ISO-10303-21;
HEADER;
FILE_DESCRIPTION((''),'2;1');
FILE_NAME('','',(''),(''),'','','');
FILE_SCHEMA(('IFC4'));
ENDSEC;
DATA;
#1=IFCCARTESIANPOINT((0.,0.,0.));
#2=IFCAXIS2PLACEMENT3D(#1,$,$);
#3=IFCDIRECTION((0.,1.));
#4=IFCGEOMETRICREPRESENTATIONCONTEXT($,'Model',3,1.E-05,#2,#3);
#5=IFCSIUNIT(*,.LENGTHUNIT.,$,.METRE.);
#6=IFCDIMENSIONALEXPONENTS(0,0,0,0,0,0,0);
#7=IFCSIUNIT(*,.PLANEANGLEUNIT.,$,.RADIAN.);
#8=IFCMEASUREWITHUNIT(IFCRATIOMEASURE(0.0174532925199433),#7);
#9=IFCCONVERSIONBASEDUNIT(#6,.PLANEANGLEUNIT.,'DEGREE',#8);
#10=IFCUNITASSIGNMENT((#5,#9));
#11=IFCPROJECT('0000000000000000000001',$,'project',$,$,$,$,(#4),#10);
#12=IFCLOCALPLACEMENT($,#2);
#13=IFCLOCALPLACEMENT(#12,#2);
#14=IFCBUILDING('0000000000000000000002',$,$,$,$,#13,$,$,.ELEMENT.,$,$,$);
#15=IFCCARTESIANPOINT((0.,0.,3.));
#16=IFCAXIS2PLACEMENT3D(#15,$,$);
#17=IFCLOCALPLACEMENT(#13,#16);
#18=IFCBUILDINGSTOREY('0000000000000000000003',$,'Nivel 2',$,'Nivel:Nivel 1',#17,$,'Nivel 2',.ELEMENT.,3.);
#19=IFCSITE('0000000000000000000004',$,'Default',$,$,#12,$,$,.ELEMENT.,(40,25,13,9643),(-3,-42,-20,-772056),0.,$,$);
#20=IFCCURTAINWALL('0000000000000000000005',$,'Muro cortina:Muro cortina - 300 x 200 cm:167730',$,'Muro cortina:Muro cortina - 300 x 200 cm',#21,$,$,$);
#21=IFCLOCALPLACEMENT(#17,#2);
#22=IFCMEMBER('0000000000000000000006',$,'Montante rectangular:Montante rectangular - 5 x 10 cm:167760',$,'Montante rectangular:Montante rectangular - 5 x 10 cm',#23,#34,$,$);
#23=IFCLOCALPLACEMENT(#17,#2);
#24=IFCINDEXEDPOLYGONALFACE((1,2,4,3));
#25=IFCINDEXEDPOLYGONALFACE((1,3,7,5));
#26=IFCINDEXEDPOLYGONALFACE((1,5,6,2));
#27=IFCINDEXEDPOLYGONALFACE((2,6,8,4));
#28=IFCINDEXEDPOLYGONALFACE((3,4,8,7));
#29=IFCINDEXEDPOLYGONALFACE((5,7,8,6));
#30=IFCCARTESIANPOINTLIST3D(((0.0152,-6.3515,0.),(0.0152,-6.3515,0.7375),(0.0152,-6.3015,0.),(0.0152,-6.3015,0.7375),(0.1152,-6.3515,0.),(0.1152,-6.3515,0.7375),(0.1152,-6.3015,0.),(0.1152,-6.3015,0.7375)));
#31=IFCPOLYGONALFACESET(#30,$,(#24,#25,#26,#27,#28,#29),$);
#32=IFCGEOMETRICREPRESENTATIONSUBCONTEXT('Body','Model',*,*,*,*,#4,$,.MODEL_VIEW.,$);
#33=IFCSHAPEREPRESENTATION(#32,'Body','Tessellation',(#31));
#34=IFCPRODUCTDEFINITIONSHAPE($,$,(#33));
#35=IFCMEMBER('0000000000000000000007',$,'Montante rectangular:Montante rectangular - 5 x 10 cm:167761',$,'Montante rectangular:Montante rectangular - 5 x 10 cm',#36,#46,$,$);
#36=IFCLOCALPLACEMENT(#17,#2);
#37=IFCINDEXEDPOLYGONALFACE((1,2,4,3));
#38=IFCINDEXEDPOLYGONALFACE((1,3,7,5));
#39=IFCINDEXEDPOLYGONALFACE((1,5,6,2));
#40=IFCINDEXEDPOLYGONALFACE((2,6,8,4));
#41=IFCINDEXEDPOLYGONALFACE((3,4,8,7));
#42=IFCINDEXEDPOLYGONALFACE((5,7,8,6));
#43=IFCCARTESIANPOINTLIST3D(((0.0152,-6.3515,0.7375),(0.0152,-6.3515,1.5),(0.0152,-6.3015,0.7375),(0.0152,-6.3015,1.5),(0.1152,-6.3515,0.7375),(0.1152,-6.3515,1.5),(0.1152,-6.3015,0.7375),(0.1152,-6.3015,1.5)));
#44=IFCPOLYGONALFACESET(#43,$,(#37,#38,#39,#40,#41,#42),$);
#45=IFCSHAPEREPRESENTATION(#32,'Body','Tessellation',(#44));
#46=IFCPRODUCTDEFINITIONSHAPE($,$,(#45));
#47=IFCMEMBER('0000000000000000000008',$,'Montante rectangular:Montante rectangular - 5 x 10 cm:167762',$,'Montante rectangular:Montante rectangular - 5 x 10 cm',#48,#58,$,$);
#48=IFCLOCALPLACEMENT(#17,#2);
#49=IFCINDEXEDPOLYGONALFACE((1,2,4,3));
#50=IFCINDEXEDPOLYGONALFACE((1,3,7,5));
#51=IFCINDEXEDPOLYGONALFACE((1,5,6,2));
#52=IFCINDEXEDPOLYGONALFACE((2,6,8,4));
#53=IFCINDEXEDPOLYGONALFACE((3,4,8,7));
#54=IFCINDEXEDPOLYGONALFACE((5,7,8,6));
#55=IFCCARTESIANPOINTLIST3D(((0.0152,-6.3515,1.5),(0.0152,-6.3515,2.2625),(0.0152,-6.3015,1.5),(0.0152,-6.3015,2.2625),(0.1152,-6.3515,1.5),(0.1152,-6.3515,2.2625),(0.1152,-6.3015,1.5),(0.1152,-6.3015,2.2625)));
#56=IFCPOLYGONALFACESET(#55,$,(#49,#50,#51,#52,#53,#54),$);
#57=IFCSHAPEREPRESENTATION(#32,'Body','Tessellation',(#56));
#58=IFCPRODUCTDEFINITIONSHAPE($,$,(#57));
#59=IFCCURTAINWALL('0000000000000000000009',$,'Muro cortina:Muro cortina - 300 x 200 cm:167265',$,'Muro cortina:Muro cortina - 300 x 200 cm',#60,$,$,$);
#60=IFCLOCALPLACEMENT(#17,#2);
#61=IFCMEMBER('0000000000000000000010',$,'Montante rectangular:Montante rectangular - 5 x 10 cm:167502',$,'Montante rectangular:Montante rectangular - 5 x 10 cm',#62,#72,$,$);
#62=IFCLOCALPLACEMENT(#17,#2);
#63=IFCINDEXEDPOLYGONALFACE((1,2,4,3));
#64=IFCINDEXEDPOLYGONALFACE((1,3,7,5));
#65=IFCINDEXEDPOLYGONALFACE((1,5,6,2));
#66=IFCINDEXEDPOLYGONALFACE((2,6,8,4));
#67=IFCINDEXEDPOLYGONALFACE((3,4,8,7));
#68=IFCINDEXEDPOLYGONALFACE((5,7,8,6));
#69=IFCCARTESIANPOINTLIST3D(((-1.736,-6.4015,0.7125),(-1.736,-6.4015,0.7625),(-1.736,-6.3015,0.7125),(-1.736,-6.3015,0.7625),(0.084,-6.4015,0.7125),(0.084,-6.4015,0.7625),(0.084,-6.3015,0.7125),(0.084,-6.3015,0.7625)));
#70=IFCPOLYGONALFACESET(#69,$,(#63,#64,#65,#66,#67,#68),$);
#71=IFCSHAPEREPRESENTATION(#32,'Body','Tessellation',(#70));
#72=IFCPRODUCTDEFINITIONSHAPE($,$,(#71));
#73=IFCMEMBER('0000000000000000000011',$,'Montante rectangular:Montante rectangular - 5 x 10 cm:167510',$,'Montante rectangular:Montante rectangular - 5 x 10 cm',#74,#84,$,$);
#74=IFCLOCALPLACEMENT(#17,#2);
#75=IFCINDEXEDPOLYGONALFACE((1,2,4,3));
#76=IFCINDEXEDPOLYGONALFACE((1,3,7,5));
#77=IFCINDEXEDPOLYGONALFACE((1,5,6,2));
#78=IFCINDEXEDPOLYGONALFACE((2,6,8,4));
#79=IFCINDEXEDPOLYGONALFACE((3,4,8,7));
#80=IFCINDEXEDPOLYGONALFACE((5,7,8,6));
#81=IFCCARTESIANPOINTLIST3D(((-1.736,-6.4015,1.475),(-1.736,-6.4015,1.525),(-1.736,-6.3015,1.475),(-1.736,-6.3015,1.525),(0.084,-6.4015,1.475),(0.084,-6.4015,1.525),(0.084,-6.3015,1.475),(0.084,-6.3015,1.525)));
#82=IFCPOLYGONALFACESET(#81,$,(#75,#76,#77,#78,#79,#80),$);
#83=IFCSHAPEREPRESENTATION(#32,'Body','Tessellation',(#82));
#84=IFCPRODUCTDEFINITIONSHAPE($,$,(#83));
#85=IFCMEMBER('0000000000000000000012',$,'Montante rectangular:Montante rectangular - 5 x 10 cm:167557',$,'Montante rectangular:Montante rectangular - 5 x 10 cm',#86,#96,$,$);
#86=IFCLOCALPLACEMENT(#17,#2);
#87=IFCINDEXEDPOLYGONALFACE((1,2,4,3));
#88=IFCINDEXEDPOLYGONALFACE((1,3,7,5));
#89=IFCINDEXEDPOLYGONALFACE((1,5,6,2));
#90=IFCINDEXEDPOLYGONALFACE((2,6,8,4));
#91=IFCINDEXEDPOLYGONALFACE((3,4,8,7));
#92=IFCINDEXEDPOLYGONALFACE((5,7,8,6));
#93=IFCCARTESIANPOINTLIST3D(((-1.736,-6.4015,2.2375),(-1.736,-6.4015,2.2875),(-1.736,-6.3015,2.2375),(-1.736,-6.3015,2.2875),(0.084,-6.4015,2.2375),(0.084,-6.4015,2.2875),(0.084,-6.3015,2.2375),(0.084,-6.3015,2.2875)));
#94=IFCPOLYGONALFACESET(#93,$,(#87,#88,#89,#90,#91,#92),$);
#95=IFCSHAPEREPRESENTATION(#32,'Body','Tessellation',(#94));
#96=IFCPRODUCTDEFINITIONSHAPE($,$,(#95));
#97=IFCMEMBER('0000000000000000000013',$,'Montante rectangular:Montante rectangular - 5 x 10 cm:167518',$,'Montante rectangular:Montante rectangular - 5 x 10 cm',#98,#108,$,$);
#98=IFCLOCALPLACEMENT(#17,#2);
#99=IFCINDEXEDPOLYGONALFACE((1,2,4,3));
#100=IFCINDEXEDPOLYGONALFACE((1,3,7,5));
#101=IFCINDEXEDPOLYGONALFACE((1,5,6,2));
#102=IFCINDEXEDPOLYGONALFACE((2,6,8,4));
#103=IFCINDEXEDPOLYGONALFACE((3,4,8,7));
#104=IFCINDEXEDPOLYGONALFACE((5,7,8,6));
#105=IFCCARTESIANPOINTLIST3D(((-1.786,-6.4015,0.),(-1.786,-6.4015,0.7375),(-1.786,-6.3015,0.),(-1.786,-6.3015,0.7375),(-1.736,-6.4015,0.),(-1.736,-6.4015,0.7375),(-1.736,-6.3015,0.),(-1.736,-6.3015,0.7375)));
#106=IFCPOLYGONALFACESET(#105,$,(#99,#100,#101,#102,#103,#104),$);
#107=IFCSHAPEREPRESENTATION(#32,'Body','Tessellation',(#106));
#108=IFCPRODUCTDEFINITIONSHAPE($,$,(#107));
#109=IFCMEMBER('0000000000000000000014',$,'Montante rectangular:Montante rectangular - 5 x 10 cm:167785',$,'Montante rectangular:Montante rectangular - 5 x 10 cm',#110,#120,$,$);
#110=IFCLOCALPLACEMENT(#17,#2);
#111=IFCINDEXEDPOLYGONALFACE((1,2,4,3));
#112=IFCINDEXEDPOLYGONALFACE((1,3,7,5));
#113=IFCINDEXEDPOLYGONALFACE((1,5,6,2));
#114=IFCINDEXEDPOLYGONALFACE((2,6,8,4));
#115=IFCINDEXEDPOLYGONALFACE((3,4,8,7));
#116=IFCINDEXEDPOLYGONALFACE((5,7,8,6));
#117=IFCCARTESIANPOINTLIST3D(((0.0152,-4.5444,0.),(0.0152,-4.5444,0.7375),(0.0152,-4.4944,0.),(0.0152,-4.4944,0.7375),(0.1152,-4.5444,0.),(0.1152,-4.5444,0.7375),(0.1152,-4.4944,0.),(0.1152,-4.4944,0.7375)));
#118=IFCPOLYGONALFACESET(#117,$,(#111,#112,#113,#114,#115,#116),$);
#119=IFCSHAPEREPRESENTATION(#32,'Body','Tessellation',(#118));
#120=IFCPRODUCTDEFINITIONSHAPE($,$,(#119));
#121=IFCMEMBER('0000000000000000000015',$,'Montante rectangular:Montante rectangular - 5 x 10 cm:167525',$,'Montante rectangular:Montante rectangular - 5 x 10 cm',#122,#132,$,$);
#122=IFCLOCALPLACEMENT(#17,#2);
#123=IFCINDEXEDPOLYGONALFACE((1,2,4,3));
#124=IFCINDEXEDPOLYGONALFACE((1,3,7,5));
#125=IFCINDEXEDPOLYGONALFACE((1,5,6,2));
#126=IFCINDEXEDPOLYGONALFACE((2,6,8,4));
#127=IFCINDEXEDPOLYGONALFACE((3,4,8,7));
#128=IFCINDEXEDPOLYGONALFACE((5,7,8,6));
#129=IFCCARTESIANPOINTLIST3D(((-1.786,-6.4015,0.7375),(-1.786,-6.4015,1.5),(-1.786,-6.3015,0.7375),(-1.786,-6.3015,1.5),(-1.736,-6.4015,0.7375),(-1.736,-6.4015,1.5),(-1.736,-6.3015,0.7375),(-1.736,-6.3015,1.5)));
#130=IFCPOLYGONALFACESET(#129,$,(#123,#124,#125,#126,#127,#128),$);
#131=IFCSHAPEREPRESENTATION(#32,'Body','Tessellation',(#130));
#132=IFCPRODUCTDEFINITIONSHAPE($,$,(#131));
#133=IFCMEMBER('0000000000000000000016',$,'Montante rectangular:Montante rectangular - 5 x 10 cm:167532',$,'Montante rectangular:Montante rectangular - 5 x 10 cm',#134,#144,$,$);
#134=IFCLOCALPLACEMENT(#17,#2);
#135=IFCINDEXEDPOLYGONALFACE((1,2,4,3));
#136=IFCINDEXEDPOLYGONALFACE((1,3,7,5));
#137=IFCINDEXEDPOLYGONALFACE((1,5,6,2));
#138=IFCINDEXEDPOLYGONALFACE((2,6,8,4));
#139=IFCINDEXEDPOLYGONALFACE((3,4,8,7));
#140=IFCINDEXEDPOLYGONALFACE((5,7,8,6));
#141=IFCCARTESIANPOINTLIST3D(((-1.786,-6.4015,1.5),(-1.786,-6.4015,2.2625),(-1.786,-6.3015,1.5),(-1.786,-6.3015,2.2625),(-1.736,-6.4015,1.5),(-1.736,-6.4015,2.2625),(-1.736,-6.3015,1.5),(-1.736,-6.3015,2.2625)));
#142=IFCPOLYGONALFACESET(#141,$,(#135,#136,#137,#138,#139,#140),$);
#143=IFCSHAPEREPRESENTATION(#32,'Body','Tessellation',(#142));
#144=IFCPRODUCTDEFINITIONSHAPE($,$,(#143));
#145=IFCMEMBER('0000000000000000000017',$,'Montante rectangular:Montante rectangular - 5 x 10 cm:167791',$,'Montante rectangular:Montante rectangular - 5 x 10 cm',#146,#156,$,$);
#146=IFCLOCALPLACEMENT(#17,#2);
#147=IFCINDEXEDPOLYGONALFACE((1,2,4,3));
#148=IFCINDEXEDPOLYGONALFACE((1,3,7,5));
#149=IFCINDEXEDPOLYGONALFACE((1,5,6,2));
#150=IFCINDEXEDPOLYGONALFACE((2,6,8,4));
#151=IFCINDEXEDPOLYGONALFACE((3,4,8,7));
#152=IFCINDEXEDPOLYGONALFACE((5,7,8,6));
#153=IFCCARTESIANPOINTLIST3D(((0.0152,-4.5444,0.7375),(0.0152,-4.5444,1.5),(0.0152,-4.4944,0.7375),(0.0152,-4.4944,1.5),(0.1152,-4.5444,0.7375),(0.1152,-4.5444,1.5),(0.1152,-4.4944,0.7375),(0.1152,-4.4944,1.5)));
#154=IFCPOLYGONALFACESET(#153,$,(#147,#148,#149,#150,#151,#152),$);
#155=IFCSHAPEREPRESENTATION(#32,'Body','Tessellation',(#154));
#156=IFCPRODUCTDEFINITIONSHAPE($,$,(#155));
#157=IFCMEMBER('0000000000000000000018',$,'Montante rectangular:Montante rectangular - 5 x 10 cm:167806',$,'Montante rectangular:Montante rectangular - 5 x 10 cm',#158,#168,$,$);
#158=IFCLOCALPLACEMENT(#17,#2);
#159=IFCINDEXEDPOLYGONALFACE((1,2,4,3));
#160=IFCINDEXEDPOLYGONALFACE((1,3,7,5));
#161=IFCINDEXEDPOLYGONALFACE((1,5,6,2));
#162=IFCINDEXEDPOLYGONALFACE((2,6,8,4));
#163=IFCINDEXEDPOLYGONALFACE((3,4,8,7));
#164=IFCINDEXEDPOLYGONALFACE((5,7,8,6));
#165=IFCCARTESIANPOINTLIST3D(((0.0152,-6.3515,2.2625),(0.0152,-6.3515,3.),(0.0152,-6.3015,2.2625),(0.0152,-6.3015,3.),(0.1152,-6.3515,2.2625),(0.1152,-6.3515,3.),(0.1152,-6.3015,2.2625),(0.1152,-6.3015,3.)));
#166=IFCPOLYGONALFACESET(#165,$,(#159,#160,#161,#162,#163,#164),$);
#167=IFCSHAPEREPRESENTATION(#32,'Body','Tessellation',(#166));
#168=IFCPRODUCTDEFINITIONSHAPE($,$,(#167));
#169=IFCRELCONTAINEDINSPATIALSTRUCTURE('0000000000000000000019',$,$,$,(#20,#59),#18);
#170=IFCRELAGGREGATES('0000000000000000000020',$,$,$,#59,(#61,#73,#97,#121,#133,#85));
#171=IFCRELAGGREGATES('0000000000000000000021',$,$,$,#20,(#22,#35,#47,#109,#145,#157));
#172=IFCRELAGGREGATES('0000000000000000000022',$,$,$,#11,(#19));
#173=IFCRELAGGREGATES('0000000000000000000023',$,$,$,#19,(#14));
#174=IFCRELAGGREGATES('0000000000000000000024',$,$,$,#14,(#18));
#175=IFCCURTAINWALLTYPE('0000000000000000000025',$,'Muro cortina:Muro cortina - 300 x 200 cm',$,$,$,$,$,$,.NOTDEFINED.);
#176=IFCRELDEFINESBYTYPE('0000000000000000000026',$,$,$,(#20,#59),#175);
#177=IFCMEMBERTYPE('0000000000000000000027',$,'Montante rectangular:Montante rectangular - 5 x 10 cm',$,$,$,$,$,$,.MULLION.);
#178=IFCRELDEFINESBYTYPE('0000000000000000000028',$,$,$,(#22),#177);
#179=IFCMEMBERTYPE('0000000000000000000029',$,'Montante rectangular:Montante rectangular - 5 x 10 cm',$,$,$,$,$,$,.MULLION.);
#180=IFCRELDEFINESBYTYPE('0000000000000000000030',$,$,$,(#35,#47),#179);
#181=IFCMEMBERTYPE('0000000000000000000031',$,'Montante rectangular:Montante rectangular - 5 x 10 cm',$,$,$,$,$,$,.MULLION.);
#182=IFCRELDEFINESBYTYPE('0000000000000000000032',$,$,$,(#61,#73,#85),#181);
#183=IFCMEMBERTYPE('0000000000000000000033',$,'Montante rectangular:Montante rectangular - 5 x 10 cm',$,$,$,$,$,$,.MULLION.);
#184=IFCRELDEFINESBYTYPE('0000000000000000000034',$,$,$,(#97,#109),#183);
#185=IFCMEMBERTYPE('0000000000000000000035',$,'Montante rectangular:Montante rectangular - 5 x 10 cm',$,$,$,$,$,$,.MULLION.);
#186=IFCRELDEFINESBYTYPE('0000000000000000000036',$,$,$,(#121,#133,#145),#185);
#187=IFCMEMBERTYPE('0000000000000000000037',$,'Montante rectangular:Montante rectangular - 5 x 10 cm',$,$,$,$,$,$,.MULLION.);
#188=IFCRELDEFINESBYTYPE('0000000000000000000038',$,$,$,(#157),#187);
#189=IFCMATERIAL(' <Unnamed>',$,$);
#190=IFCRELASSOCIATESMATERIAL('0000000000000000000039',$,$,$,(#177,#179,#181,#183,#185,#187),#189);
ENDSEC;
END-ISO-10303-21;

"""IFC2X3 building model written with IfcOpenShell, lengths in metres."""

from ifc_helpers import new_model, entity, si_unit, converted_unit, direction, frame, origin, origin_2d_with_axis, place, context, subcontext, project, spatial, rectangle, extrude, source, transform, mapped, material, type_object, type_shapes, element, aggregate, save


model = new_model("IFC2X3")

# Units and contexts
model_context = context("Model", 3, precision=1e-05, world=origin(), true_north=direction((0.0, 1.0)))
body_context = subcontext(model_context, "Body", "Model", "MODEL_VIEW")
ifc_project = project(units=[si_unit("LENGTHUNIT", "METRE"), converted_unit("PLANEANGLEUNIT", "DEGREE", entity("IfcRatioMeasure", 0.0174532925199433), si_unit("PLANEANGLEUNIT", "RADIAN"), dimensions=[0, 0, 0, 0, 0, 0, 0])], contexts=[model_context])

# Site, building, storey
site_placement = place(None, origin())
site = spatial("IfcSite", under=ifc_project, at=site_placement, Name="Default", CompositionType="ELEMENT", RefLatitude=(40, 25, 13, 9643), RefLongitude=(-3, -42, -20, -772056), RefElevation=0.0)
building_placement = place(site_placement, origin())
building = spatial("IfcBuilding", under=site, at=building_placement, CompositionType="ELEMENT")
storey_placement = place(building_placement, frame((0.0, 0.0, 3.0)))
storey = spatial("IfcBuildingStorey", under=building, at=storey_placement, Name="Nivel 2", ObjectType="Nivel:Nivel 1", LongName="Nivel 2", CompositionType="ELEMENT", Elevation=3.0)

# Curtain walls, members
curtain_wall_type = type_object("IfcCurtainWallType", Name="Muro cortina:Muro cortina - 300 x 200 cm", PredefinedType="NOTDEFINED")
curtain_wall_1_placement = place(storey_placement, frame((0.0, 0.0, -3.0)))
curtain_wall_1 = element("IfcCurtainWall", 1, at=curtain_wall_1_placement, inside=storey, type_object=curtain_wall_type, Name="Muro cortina:Muro cortina - 300 x 200 cm:167730", ObjectType="Muro cortina:Muro cortina - 300 x 200 cm")
ifc_material_1 = material(Name=" <Unnamed>")
member_type_1 = type_object("IfcMemberType", Name="Montante rectangular:Montante rectangular - 5 x 10 cm", PredefinedType="MULLION", material=ifc_material_1)
shared_shape_1 = source(origin(), body_context, "Body", "SweptSolid", [
    extrude(rectangle(XDim=0.1, YDim=0.05, at=origin_2d_with_axis()), frame((-0.025, 0.0, -0.7375), z_axis=(0.0, 0.0, 1.0), x_axis=(0.0, -1.0, 0.0)), (0.0, 0.0, 1.0), 0.7375),
])
type_shapes(member_type_1, [shared_shape_1])
member_1_placement = place(storey_placement, frame((0.0652, -6.3515, 0.0), z_axis=(0.0, 0.0, -1.0), x_axis=(0.0, -1.0, 0.0)))
member_1 = element("IfcMember", 2, at=member_1_placement, type_object=member_type_1, Name="Montante rectangular:Montante rectangular - 5 x 10 cm:167760", ObjectType="Montante rectangular:Montante rectangular - 5 x 10 cm", context=body_context, shape_type="MappedRepresentation", body=[
    mapped(shared_shape_1, transform((0.0, 0.0, 0.0), scale=1.0)),
])
member_type_2 = type_object("IfcMemberType", Name="Montante rectangular:Montante rectangular - 5 x 10 cm", PredefinedType="MULLION", material=ifc_material_1)
shared_shape_2 = source(origin(), body_context, "Body", "SweptSolid", [
    extrude(rectangle(XDim=0.1, YDim=0.05, at=origin_2d_with_axis()), frame((-0.025, 0.0, -0.7625), z_axis=(0.0, 0.0, 1.0), x_axis=(0.0, -1.0, 0.0)), (0.0, 0.0, 1.0), 0.7625),
])
type_shapes(member_type_2, [shared_shape_2])
member_2_placement = place(storey_placement, frame((0.0652, -6.3515, 0.7375), z_axis=(0.0, 0.0, -1.0), x_axis=(0.0, -1.0, 0.0)))
member_2 = element("IfcMember", 3, at=member_2_placement, type_object=member_type_2, Name="Montante rectangular:Montante rectangular - 5 x 10 cm:167761", ObjectType="Montante rectangular:Montante rectangular - 5 x 10 cm", context=body_context, shape_type="MappedRepresentation", body=[
    mapped(shared_shape_2, transform((0.0, 0.0, 0.0), scale=1.0)),
])
member_3_placement = place(storey_placement, frame((0.0652, -6.3515, 1.5), z_axis=(0.0, 0.0, -1.0), x_axis=(0.0, -1.0, 0.0)))
member_3 = element("IfcMember", 4, at=member_3_placement, type_object=member_type_2, Name="Montante rectangular:Montante rectangular - 5 x 10 cm:167762", ObjectType="Montante rectangular:Montante rectangular - 5 x 10 cm", context=body_context, shape_type="MappedRepresentation", body=[
    mapped(shared_shape_2, transform((0.0, 0.0, 0.0), scale=1.0)),
])
curtain_wall_2_placement = place(storey_placement, frame((0.0, 0.0, -3.0)))
curtain_wall_2 = element("IfcCurtainWall", 5, at=curtain_wall_2_placement, inside=storey, type_object=curtain_wall_type, Name="Muro cortina:Muro cortina - 300 x 200 cm:167265", ObjectType="Muro cortina:Muro cortina - 300 x 200 cm")
member_type_3 = type_object("IfcMemberType", Name="Montante rectangular:Montante rectangular - 5 x 10 cm", PredefinedType="MULLION", material=ifc_material_1)
shared_shape_3 = source(origin(), body_context, "Body", "SweptSolid", [
    extrude(rectangle(XDim=0.1, YDim=0.05, at=origin_2d_with_axis()), frame((0.0, 0.0, -1.82), z_axis=(0.0, 0.0, 1.0), x_axis=(0.0, -1.0, 0.0)), (0.0, 0.0, 1.0), 1.82),
])
type_shapes(member_type_3, [shared_shape_3])
member_4_placement = place(storey_placement, frame((-1.736, -6.3515, 0.7375), z_axis=(-1.0, 0.0, 0.0), x_axis=(0.0, 0.0, 1.0)))
member_4 = element("IfcMember", 6, at=member_4_placement, type_object=member_type_3, Name="Montante rectangular:Montante rectangular - 5 x 10 cm:167502", ObjectType="Montante rectangular:Montante rectangular - 5 x 10 cm", context=body_context, shape_type="MappedRepresentation", body=[
    mapped(shared_shape_3, transform((0.0, 0.0, 0.0), scale=1.0)),
])
member_5_placement = place(storey_placement, frame((-1.736, -6.3515, 1.5), z_axis=(-1.0, 0.0, 0.0), x_axis=(0.0, 0.0, 1.0)))
member_5 = element("IfcMember", 7, at=member_5_placement, type_object=member_type_3, Name="Montante rectangular:Montante rectangular - 5 x 10 cm:167510", ObjectType="Montante rectangular:Montante rectangular - 5 x 10 cm", context=body_context, shape_type="MappedRepresentation", body=[
    mapped(shared_shape_3, transform((0.0, 0.0, 0.0), scale=1.0)),
])
member_6_placement = place(storey_placement, frame((-1.736, -6.3515, 2.2625), z_axis=(-1.0, 0.0, 0.0), x_axis=(0.0, 0.0, 1.0)))
member_6 = element("IfcMember", 8, at=member_6_placement, type_object=member_type_3, Name="Montante rectangular:Montante rectangular - 5 x 10 cm:167557", ObjectType="Montante rectangular:Montante rectangular - 5 x 10 cm", context=body_context, shape_type="MappedRepresentation", body=[
    mapped(shared_shape_3, transform((0.0, 0.0, 0.0), scale=1.0)),
])
member_type_4 = type_object("IfcMemberType", Name="Montante rectangular:Montante rectangular - 5 x 10 cm", PredefinedType="MULLION", material=ifc_material_1)
shared_shape_4 = source(origin(), body_context, "Body", "SweptSolid", [
    extrude(rectangle(XDim=0.1, YDim=0.05, at=origin_2d_with_axis()), frame((0.0, 0.0, -0.7375), z_axis=(0.0, 0.0, 1.0), x_axis=(0.0, -1.0, 0.0)), (0.0, 0.0, 1.0), 0.7375),
])
type_shapes(member_type_4, [shared_shape_4])
member_7_placement = place(storey_placement, frame((-1.761, -6.3515, 0.0), z_axis=(0.0, 0.0, -1.0), x_axis=(-1.0, 0.0, 0.0)))
member_7 = element("IfcMember", 9, at=member_7_placement, type_object=member_type_4, Name="Montante rectangular:Montante rectangular - 5 x 10 cm:167518", ObjectType="Montante rectangular:Montante rectangular - 5 x 10 cm", context=body_context, shape_type="MappedRepresentation", body=[
    mapped(shared_shape_4, transform((0.0, 0.0, 0.0), scale=1.0)),
])

# Members
member_8_placement = place(storey_placement, frame((0.0652, -4.5194, 0.0), z_axis=(0.0, 0.0, -1.0), x_axis=(0.0, -1.0, 0.0)))
member_8 = element("IfcMember", 10, at=member_8_placement, type_object=member_type_4, Name="Montante rectangular:Montante rectangular - 5 x 10 cm:167785", ObjectType="Montante rectangular:Montante rectangular - 5 x 10 cm", context=body_context, shape_type="MappedRepresentation", body=[
    mapped(shared_shape_4, transform((0.0, 0.0, 0.0), scale=1.0)),
])
member_type_5 = type_object("IfcMemberType", Name="Montante rectangular:Montante rectangular - 5 x 10 cm", PredefinedType="MULLION", material=ifc_material_1)
shared_shape_5 = source(origin(), body_context, "Body", "SweptSolid", [
    extrude(rectangle(XDim=0.1, YDim=0.05, at=origin_2d_with_axis()), frame((0.0, 0.0, -0.7625), z_axis=(0.0, 0.0, 1.0), x_axis=(0.0, -1.0, 0.0)), (0.0, 0.0, 1.0), 0.7625),
])
type_shapes(member_type_5, [shared_shape_5])
member_9_placement = place(storey_placement, frame((-1.761, -6.3515, 0.7375), z_axis=(0.0, 0.0, -1.0), x_axis=(-1.0, 0.0, 0.0)))
member_9 = element("IfcMember", 11, at=member_9_placement, type_object=member_type_5, Name="Montante rectangular:Montante rectangular - 5 x 10 cm:167525", ObjectType="Montante rectangular:Montante rectangular - 5 x 10 cm", context=body_context, shape_type="MappedRepresentation", body=[
    mapped(shared_shape_5, transform((0.0, 0.0, 0.0), scale=1.0)),
])
member_10_placement = place(storey_placement, frame((-1.761, -6.3515, 1.5), z_axis=(0.0, 0.0, -1.0), x_axis=(-1.0, 0.0, 0.0)))
member_10 = element("IfcMember", 12, at=member_10_placement, type_object=member_type_5, Name="Montante rectangular:Montante rectangular - 5 x 10 cm:167532", ObjectType="Montante rectangular:Montante rectangular - 5 x 10 cm", context=body_context, shape_type="MappedRepresentation", body=[
    mapped(shared_shape_5, transform((0.0, 0.0, 0.0), scale=1.0)),
])
member_11_placement = place(storey_placement, frame((0.0652, -4.5194, 0.7375), z_axis=(0.0, 0.0, -1.0), x_axis=(0.0, -1.0, 0.0)))
member_11 = element("IfcMember", 13, at=member_11_placement, type_object=member_type_5, Name="Montante rectangular:Montante rectangular - 5 x 10 cm:167791", ObjectType="Montante rectangular:Montante rectangular - 5 x 10 cm", context=body_context, shape_type="MappedRepresentation", body=[
    mapped(shared_shape_5, transform((0.0, 0.0, 0.0), scale=1.0)),
])
member_type_6 = type_object("IfcMemberType", Name="Montante rectangular:Montante rectangular - 5 x 10 cm", PredefinedType="MULLION", material=ifc_material_1)
shared_shape_6 = source(origin(), body_context, "Body", "SweptSolid", [
    extrude(rectangle(XDim=0.1, YDim=0.05, at=origin_2d_with_axis()), frame((-0.025, 0.0, -0.7375), z_axis=(0.0, 0.0, 1.0), x_axis=(0.0, -1.0, 0.0)), (0.0, 0.0, 1.0), 0.7375),
])
type_shapes(member_type_6, [shared_shape_6])
member_12_placement = place(storey_placement, frame((0.0652, -6.3515, 2.2625), z_axis=(0.0, 0.0, -1.0), x_axis=(0.0, -1.0, 0.0)))
member_12 = element("IfcMember", 14, at=member_12_placement, type_object=member_type_6, Name="Montante rectangular:Montante rectangular - 5 x 10 cm:167806", ObjectType="Montante rectangular:Montante rectangular - 5 x 10 cm", context=body_context, shape_type="MappedRepresentation", body=[
    mapped(shared_shape_6, transform((0.0, 0.0, 0.0), scale=1.0)),
])

aggregate(curtain_wall_2, [member_4, member_5, member_7, member_9, member_10, member_6])
aggregate(curtain_wall_1, [member_1, member_2, member_3, member_8, member_11, member_12])

save(model, "model.ifc")
